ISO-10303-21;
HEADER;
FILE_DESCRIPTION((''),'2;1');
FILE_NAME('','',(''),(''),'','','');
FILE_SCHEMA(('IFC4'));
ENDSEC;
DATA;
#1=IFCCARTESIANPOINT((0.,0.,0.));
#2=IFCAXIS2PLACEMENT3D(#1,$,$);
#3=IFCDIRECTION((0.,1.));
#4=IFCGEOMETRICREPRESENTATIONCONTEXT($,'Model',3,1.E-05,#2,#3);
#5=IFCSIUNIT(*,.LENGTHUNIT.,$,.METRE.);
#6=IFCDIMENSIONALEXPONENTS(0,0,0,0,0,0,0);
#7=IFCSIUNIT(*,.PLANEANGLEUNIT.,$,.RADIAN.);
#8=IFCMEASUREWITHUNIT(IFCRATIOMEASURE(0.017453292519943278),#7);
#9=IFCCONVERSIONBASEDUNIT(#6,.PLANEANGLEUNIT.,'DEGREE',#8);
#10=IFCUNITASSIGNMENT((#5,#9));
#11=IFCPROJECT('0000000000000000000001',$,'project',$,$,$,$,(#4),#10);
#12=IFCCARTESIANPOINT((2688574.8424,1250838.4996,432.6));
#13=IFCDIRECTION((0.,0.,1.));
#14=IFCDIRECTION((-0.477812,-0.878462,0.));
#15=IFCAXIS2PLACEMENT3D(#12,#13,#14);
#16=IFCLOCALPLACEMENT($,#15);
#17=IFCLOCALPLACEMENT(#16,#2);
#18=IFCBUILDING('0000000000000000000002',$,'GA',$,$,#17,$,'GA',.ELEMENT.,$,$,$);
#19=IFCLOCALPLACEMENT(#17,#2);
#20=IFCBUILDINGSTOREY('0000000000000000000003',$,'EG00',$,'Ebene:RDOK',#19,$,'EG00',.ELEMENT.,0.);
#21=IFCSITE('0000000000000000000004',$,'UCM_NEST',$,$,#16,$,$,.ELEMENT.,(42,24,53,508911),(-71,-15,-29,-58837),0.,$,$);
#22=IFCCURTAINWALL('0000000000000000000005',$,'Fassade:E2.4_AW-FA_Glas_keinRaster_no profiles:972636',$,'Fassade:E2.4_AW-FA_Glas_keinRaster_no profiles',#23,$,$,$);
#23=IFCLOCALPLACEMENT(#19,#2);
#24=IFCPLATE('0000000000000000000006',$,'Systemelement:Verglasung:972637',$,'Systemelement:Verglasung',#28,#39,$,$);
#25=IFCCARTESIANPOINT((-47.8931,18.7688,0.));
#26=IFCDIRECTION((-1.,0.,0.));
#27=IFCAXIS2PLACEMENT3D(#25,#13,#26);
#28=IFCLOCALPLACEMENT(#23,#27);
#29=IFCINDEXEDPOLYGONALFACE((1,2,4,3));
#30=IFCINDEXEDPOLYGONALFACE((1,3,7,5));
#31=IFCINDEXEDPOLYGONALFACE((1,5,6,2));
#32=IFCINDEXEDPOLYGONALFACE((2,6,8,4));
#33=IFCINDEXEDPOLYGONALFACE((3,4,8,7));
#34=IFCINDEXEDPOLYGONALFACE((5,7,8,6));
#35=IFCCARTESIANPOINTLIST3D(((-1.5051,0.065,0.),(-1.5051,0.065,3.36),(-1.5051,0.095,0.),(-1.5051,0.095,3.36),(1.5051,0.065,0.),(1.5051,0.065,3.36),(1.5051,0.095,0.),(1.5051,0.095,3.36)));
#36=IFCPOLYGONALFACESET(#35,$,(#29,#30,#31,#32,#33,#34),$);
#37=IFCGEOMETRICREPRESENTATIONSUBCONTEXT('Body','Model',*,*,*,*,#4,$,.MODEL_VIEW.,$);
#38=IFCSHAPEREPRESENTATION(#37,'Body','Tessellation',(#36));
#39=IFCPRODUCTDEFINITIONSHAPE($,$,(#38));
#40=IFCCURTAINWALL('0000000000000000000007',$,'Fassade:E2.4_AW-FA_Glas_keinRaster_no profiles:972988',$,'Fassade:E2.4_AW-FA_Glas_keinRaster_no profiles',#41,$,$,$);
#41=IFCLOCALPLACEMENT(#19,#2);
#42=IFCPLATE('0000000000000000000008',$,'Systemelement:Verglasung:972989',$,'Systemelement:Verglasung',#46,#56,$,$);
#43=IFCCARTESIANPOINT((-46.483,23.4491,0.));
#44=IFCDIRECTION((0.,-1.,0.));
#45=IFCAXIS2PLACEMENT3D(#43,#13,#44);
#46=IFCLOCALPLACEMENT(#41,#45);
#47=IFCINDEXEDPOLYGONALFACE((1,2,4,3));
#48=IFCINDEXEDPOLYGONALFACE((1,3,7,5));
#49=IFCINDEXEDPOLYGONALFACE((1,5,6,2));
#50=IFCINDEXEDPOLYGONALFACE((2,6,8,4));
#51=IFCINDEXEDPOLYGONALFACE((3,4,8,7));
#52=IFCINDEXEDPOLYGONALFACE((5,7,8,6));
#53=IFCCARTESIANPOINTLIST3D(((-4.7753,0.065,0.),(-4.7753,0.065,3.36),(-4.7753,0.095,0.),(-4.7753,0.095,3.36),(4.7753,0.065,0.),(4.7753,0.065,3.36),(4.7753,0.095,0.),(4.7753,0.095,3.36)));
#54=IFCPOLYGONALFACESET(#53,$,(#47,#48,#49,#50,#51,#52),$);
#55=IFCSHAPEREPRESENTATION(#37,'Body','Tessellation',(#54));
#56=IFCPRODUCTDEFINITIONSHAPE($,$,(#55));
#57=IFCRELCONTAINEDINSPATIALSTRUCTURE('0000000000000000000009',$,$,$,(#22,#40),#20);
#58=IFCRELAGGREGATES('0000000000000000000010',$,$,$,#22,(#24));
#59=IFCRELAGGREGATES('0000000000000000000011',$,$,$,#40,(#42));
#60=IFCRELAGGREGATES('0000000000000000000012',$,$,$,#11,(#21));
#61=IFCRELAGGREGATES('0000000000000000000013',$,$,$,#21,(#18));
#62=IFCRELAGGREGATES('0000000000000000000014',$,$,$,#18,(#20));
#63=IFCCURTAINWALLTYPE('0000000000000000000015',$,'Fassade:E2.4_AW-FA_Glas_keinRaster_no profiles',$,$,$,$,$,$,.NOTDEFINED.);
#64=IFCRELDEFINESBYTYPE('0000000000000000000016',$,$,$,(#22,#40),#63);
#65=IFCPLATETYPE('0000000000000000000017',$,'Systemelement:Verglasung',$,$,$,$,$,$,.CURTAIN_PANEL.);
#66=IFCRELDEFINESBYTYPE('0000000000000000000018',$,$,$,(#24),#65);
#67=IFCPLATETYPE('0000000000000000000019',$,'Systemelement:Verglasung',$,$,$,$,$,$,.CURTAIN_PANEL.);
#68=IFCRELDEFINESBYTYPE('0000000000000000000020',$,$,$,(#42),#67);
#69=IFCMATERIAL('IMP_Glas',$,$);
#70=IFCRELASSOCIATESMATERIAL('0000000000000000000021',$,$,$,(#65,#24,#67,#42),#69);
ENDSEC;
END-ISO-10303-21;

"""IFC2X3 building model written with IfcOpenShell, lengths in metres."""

from ifc_helpers import new_model, entity, si_unit, converted_unit, direction, frame, frame_2d, origin, place, context, subcontext, project, spatial, rectangle, extrude, source, transform, mapped, material, type_object, type_shapes, element, aggregate, save


model = new_model("IFC2X3")

# Units and contexts
model_context = context("Model", 3, precision=1e-05, world=origin(), true_north=direction((0.0, 1.0)))
body_context = subcontext(model_context, "Body", "Model", "MODEL_VIEW")
ifc_project = project(units=[si_unit("LENGTHUNIT", "METRE"), converted_unit("PLANEANGLEUNIT", "DEGREE", entity("IfcRatioMeasure", 0.017453292519943278), si_unit("PLANEANGLEUNIT", "RADIAN"), dimensions=[0, 0, 0, 0, 0, 0, 0])], contexts=[model_context])

# Site, building, storey
site_placement = place(None, frame((2688574.8424, 1250838.4996, 432.6), z_axis=(0.0, 0.0, 1.0), x_axis=(-0.477812, -0.878462, 0.0)))
site = spatial("IfcSite", under=ifc_project, at=site_placement, Name="UCM_NEST", CompositionType="ELEMENT", RefLatitude=(42, 24, 53, 508911), RefLongitude=(-71, -15, -29, -58837), RefElevation=0.0)
building_placement = place(site_placement, origin())
building = spatial("IfcBuilding", under=site, at=building_placement, Name="GA", LongName="GA", CompositionType="ELEMENT")
storey_placement = place(building_placement, origin())
storey = spatial("IfcBuildingStorey", under=building, at=storey_placement, Name="EG00", ObjectType="Ebene:RDOK", LongName="EG00", CompositionType="ELEMENT", Elevation=0.0)

# Curtain walls, plates
curtain_wall_type = type_object("IfcCurtainWallType", Name="Fassade:E2.4_AW-FA_Glas_keinRaster_no profiles", PredefinedType="NOTDEFINED")
curtain_wall_1_placement = place(storey_placement, origin())
curtain_wall_1 = element("IfcCurtainWall", 1, at=curtain_wall_1_placement, inside=storey, type_object=curtain_wall_type, Name="Fassade:E2.4_AW-FA_Glas_keinRaster_no profiles:972636", ObjectType="Fassade:E2.4_AW-FA_Glas_keinRaster_no profiles")
ifc_material_1 = material(Name="IMP_Glas")
plate_type_1 = type_object("IfcPlateType", Name="Systemelement:Verglasung", PredefinedType="CURTAIN_PANEL", material=ifc_material_1)
shared_shape_1 = source(origin(), body_context, "Body", "SweptSolid", [
    extrude(rectangle(XDim=0.03, YDim=3.0101, at=frame_2d((0.0, 0.0), x_axis=(1.0, 0.0))), frame((0.0, 0.08, 0.0), z_axis=(0.0, 0.0, 1.0), x_axis=(0.0, 1.0, 0.0)), (0.0, 0.0, 1.0), 3.36),
])
type_shapes(plate_type_1, [shared_shape_1])
plate_1_placement = place(curtain_wall_1_placement, frame((-47.8931, 18.7688, 0.0), z_axis=(0.0, 0.0, 1.0), x_axis=(-1.0, 0.0, 0.0)))
plate_1 = element("IfcPlate", 2, at=plate_1_placement, type_object=plate_type_1, material=ifc_material_1, Name="Systemelement:Verglasung:972637", ObjectType="Systemelement:Verglasung", context=body_context, shape_type="MappedRepresentation", body=[
    mapped(shared_shape_1, transform((0.0, 0.0, 0.0), scale=1.0)),
])
aggregate(curtain_wall_1, [plate_1])
curtain_wall_2_placement = place(storey_placement, origin())
curtain_wall_2 = element("IfcCurtainWall", 3, at=curtain_wall_2_placement, inside=storey, type_object=curtain_wall_type, Name="Fassade:E2.4_AW-FA_Glas_keinRaster_no profiles:972988", ObjectType="Fassade:E2.4_AW-FA_Glas_keinRaster_no profiles")
plate_type_2 = type_object("IfcPlateType", Name="Systemelement:Verglasung", PredefinedType="CURTAIN_PANEL", material=ifc_material_1)
shared_shape_2 = source(origin(), body_context, "Body", "SweptSolid", [
    extrude(rectangle(XDim=0.03, YDim=9.5506, at=frame_2d((0.0, 0.0), x_axis=(1.0, 0.0))), frame((0.0, 0.08, 0.0), z_axis=(0.0, 0.0, 1.0), x_axis=(0.0, 1.0, 0.0)), (0.0, 0.0, 1.0), 3.36),
])
type_shapes(plate_type_2, [shared_shape_2])
plate_2_placement = place(curtain_wall_2_placement, frame((-46.483, 23.4491, 0.0), z_axis=(0.0, 0.0, 1.0), x_axis=(0.0, -1.0, 0.0)))
plate_2 = element("IfcPlate", 4, at=plate_2_placement, type_object=plate_type_2, material=ifc_material_1, Name="Systemelement:Verglasung:972989", ObjectType="Systemelement:Verglasung", context=body_context, shape_type="MappedRepresentation", body=[
    mapped(shared_shape_2, transform((0.0, 0.0, 0.0), scale=1.0)),
])
aggregate(curtain_wall_2, [plate_2])

save(model, "model.ifc")
